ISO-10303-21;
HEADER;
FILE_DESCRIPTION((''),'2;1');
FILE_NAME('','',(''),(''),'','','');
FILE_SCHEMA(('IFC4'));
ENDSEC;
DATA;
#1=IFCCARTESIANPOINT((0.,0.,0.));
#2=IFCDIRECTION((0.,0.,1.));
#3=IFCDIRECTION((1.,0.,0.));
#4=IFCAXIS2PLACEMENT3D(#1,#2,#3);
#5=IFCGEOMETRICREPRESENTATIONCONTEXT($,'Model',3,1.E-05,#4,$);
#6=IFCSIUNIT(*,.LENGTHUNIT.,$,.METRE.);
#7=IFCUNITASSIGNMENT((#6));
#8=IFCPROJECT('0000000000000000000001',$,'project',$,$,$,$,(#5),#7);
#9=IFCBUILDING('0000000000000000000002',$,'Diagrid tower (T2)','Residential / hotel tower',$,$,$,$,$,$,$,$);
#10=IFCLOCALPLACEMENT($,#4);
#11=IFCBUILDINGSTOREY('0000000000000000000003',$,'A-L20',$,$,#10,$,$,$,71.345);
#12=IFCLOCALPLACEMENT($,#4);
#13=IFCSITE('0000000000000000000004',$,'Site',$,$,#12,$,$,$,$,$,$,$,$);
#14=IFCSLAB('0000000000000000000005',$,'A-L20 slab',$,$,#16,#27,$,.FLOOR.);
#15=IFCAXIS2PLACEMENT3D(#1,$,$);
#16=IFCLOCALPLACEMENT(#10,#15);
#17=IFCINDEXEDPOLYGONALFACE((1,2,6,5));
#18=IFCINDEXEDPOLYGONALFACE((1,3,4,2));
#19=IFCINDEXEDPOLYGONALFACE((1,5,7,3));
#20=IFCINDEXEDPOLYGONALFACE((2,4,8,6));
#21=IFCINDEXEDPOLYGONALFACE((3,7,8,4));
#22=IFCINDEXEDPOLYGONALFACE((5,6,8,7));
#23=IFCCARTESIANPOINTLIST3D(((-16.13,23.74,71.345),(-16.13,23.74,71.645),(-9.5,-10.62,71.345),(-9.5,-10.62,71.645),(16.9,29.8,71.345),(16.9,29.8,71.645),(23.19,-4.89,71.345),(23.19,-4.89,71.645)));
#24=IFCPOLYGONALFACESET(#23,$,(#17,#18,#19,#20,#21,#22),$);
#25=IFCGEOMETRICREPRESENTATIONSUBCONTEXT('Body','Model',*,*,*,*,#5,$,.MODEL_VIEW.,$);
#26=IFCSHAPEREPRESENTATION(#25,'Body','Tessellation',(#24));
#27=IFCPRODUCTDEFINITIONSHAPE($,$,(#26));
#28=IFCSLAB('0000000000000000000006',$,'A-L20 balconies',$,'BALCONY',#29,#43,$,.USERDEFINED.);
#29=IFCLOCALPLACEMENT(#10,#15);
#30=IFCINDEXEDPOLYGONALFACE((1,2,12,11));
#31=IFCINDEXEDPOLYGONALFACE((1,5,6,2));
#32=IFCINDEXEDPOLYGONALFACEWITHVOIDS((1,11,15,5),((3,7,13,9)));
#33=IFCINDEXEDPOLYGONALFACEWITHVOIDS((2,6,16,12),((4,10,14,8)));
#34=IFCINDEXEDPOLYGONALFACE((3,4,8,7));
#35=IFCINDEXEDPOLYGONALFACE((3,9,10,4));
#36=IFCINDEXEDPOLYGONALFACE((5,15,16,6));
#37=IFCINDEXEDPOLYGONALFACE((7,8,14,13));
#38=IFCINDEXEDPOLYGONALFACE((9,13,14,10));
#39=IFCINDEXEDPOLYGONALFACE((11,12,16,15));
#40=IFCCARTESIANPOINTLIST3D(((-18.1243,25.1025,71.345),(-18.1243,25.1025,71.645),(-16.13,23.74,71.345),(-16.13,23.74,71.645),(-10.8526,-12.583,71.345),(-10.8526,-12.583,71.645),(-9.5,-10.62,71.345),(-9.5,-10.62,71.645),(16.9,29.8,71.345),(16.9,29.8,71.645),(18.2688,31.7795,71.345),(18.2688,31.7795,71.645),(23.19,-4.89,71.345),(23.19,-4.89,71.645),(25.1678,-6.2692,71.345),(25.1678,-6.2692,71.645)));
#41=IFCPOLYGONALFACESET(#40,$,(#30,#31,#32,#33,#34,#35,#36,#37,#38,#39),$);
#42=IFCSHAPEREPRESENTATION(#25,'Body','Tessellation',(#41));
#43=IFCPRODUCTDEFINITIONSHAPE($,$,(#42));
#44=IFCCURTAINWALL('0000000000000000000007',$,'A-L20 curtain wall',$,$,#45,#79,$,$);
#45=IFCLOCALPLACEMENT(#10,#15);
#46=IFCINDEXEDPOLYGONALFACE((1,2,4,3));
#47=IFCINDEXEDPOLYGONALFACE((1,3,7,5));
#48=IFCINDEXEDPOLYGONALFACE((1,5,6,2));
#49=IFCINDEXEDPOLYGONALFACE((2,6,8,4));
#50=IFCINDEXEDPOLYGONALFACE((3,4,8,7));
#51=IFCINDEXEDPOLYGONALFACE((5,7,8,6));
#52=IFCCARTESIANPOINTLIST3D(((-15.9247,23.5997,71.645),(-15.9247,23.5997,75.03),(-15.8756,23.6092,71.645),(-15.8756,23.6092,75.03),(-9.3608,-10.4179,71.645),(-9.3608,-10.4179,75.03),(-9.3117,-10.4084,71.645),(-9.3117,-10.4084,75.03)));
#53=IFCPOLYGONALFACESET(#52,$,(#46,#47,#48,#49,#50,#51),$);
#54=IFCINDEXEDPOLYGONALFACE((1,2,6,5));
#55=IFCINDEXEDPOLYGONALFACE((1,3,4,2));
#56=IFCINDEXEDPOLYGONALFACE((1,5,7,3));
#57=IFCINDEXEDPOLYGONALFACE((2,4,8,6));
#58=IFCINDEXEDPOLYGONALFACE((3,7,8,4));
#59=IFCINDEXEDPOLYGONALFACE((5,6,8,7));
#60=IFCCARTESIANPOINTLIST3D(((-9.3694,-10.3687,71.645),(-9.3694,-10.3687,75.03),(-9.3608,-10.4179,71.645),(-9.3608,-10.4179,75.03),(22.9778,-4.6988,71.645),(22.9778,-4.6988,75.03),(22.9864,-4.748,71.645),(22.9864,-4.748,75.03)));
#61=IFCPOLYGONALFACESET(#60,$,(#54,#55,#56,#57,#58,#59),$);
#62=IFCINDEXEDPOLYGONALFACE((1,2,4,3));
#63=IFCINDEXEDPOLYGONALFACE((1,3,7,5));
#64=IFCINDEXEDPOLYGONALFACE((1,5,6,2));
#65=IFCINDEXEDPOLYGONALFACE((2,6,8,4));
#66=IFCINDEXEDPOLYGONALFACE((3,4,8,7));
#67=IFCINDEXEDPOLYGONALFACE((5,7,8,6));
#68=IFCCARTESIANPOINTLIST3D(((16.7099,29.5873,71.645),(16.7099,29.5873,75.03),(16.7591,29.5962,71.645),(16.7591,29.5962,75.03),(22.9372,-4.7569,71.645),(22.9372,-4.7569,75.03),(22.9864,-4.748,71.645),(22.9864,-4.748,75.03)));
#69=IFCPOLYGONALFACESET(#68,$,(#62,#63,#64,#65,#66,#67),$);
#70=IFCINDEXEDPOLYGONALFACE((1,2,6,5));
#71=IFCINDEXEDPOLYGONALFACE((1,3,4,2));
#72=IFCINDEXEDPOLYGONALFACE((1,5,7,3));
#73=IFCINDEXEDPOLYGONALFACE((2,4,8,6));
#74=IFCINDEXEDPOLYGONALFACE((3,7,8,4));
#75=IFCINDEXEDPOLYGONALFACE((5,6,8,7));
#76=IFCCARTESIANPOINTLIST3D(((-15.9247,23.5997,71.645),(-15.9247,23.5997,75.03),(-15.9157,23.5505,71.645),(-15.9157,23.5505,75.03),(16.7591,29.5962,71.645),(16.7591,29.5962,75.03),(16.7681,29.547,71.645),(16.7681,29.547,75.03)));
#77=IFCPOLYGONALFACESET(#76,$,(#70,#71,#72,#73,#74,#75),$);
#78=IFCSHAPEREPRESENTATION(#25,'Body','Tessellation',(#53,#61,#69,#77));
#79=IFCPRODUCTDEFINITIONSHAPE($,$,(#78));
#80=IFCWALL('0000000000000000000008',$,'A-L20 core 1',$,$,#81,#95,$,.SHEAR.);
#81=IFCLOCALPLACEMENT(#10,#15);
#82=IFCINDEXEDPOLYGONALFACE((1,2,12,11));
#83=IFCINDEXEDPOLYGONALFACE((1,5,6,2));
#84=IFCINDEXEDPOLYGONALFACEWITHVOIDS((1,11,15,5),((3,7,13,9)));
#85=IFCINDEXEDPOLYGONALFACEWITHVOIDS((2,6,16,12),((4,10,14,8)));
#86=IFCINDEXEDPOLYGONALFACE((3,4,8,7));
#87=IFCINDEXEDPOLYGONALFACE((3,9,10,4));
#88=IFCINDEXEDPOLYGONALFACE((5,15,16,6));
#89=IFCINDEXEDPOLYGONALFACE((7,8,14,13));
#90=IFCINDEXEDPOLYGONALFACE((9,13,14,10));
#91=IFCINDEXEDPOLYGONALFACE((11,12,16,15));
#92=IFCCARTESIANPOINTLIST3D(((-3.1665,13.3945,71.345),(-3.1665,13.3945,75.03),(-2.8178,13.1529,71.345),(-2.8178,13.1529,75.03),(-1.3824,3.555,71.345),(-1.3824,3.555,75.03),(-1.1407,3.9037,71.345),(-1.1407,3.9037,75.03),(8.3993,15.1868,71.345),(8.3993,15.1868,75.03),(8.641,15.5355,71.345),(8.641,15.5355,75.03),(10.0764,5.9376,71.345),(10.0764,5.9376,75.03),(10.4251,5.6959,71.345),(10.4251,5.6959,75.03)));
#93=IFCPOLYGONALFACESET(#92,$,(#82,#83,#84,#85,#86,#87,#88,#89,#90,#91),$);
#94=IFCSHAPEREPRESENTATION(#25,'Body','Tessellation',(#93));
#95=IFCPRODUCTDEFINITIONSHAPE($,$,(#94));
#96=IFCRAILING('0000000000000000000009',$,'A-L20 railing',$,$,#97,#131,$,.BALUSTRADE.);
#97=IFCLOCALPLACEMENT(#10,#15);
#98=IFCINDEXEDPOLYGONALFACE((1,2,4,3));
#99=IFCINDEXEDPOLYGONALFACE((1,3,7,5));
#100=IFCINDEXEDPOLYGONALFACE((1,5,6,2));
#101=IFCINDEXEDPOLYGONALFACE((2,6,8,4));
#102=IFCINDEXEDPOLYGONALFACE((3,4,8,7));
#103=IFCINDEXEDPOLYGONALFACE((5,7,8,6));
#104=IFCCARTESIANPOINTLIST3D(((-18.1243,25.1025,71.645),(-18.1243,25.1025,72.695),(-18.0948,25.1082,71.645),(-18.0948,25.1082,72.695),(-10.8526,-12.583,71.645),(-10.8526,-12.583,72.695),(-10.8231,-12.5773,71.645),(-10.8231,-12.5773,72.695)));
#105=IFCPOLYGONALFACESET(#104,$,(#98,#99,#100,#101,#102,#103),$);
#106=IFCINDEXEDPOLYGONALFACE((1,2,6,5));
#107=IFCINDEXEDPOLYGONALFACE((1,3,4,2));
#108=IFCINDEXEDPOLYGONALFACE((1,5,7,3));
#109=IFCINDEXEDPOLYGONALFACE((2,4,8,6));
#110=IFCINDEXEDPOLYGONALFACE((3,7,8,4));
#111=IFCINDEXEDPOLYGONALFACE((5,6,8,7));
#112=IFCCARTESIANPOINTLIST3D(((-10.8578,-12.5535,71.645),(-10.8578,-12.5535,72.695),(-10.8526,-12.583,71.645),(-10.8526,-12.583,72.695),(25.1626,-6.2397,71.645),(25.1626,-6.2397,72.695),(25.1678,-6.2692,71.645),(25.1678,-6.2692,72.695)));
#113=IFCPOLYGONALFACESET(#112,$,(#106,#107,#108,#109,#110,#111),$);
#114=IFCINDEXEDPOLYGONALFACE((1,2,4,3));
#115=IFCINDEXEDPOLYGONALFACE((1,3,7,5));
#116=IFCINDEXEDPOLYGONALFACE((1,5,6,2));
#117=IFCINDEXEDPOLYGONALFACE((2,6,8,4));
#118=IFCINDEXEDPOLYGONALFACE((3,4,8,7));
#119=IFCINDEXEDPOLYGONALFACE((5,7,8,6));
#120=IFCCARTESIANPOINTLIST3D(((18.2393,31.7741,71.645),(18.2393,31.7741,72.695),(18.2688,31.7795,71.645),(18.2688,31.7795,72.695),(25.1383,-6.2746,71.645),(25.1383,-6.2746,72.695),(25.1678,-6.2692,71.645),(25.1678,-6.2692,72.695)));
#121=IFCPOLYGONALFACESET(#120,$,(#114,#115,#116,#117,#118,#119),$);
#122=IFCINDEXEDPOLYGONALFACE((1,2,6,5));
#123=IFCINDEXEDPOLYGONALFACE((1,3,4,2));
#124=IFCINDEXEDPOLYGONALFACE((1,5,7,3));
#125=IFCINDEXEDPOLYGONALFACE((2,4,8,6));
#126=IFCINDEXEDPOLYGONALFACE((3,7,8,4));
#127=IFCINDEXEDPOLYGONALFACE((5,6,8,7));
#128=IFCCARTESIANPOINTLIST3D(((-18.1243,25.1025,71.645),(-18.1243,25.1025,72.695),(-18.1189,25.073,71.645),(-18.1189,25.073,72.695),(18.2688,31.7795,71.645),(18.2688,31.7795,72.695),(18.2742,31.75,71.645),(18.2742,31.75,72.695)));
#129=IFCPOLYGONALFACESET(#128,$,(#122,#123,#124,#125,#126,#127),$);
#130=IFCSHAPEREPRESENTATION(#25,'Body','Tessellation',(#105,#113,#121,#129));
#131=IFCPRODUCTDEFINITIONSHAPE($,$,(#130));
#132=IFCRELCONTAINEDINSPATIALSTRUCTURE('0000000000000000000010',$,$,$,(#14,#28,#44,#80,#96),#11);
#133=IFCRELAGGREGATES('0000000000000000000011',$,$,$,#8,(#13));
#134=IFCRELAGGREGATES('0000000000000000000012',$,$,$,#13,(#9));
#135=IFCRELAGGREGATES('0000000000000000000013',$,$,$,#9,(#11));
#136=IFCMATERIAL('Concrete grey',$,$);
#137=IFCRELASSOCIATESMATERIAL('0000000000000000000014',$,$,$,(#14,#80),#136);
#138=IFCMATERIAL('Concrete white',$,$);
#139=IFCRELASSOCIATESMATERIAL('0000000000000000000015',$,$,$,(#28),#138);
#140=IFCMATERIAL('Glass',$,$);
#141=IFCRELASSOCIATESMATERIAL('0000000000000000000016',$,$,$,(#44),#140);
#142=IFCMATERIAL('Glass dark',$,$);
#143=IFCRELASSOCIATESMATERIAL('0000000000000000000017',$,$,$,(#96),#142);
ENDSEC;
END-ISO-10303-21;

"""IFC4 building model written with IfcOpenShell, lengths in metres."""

from ifc_helpers import new_model, si_unit, frame, origin_with_axes, place, context, subcontext, project, spatial, polyline, outline, extrude, material, element, save


model = new_model("IFC4")

# Units and contexts
model_context = context("Model", 3, precision=1e-05, world=origin_with_axes())
body_context = subcontext(model_context, "Body", "Model", "MODEL_VIEW")
ifc_project = project(units=[si_unit("LENGTHUNIT", "METRE")], contexts=[model_context])

# Site, building, storey
site_placement = place(None, origin_with_axes())
site = spatial("IfcSite", under=ifc_project, at=site_placement, Name="Site")
building = spatial("IfcBuilding", under=site, Name="Diagrid tower (T2)", Description="Residential / hotel tower")
storey_placement = place(None, origin_with_axes())
storey = spatial("IfcBuildingStorey", under=building, at=storey_placement, Name="A-L20", Elevation=71.345)

# Slabs
ifc_material_1 = material(Name="Concrete grey")
slab_1_placement = place(storey_placement, origin_with_axes())
element("IfcSlab", 1, at=slab_1_placement, inside=storey, material=ifc_material_1, Name="A-L20 slab", PredefinedType="FLOOR", context=body_context, shape_type="SweptSolid", body=[
    extrude(outline(polyline([(-16.13, 23.74), (-9.5, -10.62), (23.19, -4.89), (16.9, 29.8), (-16.13, 23.74)])), frame((0.0, 0.0, 71.345), z_axis=(0.0, 0.0, 1.0), x_axis=(1.0, 0.0, 0.0)), (0.0, 0.0, 1.0), 0.3),
])
ifc_material_2 = material(Name="Concrete white")
slab_2_placement = place(storey_placement, origin_with_axes())
element("IfcSlab", 2, at=slab_2_placement, inside=storey, material=ifc_material_2, Name="A-L20 balconies", ObjectType="BALCONY", PredefinedType="USERDEFINED", context=body_context, shape_type="SweptSolid", body=[
    extrude(outline(polyline([(-18.1243, 25.1025), (-10.8526, -12.583), (25.1678, -6.2692), (18.2688, 31.7795), (-18.1243, 25.1025)]), holes=[polyline([(-16.13, 23.74), (-9.5, -10.62), (23.19, -4.89), (16.9, 29.8), (-16.13, 23.74)])]), frame((0.0, 0.0, 71.345), z_axis=(0.0, 0.0, 1.0), x_axis=(1.0, 0.0, 0.0)), (0.0, 0.0, 1.0), 0.3),
])

# Curtain wall
ifc_material_3 = material(Name="Glass")
curtain_wall_placement = place(storey_placement, origin_with_axes())
element("IfcCurtainWall", 3, at=curtain_wall_placement, inside=storey, material=ifc_material_3, Name="A-L20 curtain wall", context=body_context, shape_type="SweptSolid", body=[
    extrude(outline(polyline([(-15.9247, 23.5997), (-9.3608, -10.4179), (-9.3117, -10.4084), (-15.8756, 23.6092), (-15.9247, 23.5997)])), frame((0.0, 0.0, 71.645), z_axis=(0.0, 0.0, 1.0), x_axis=(1.0, 0.0, 0.0)), (0.0, 0.0, 1.0), 3.385),
    extrude(outline(polyline([(-9.3608, -10.4179), (22.9864, -4.748), (22.9778, -4.6988), (-9.3694, -10.3687), (-9.3608, -10.4179)])), frame((0.0, 0.0, 71.645), z_axis=(0.0, 0.0, 1.0), x_axis=(1.0, 0.0, 0.0)), (0.0, 0.0, 1.0), 3.385),
    extrude(outline(polyline([(22.9864, -4.748), (16.7591, 29.5962), (16.7099, 29.5873), (22.9372, -4.7569), (22.9864, -4.748)])), frame((0.0, 0.0, 71.645), z_axis=(0.0, 0.0, 1.0), x_axis=(1.0, 0.0, 0.0)), (0.0, 0.0, 1.0), 3.385),
    extrude(outline(polyline([(16.7591, 29.5962), (-15.9247, 23.5997), (-15.9157, 23.5505), (16.7681, 29.547), (16.7591, 29.5962)])), frame((0.0, 0.0, 71.645), z_axis=(0.0, 0.0, 1.0), x_axis=(1.0, 0.0, 0.0)), (0.0, 0.0, 1.0), 3.385),
])

# Wall
wall_placement = place(storey_placement, origin_with_axes())
element("IfcWall", 4, at=wall_placement, inside=storey, material=ifc_material_1, Name="A-L20 core 1", PredefinedType="SHEAR", context=body_context, shape_type="SweptSolid", body=[
    extrude(outline(polyline([(10.4251, 5.6959), (8.641, 15.5355), (-3.1665, 13.3945), (-1.3824, 3.555), (10.4251, 5.6959)]), holes=[polyline([(10.0764, 5.9376), (8.3993, 15.1868), (-2.8178, 13.1529), (-1.1407, 3.9037), (10.0764, 5.9376)])]), frame((0.0, 0.0, 71.345), z_axis=(0.0, 0.0, 1.0), x_axis=(1.0, 0.0, 0.0)), (0.0, 0.0, 1.0), 3.685),
])

# Railing
ifc_material_4 = material(Name="Glass dark")
railing_placement = place(storey_placement, origin_with_axes())
element("IfcRailing", 5, at=railing_placement, inside=storey, material=ifc_material_4, Name="A-L20 railing", PredefinedType="BALUSTRADE", context=body_context, shape_type="SweptSolid", body=[
    extrude(outline(polyline([(-18.1243, 25.1025), (-10.8526, -12.583), (-10.8231, -12.5773), (-18.0948, 25.1082), (-18.1243, 25.1025)])), frame((0.0, 0.0, 71.645), z_axis=(0.0, 0.0, 1.0), x_axis=(1.0, 0.0, 0.0)), (0.0, 0.0, 1.0), 1.05),
    extrude(outline(polyline([(-10.8526, -12.583), (25.1678, -6.2692), (25.1626, -6.2397), (-10.8578, -12.5535), (-10.8526, -12.583)])), frame((0.0, 0.0, 71.645), z_axis=(0.0, 0.0, 1.0), x_axis=(1.0, 0.0, 0.0)), (0.0, 0.0, 1.0), 1.05),
    extrude(outline(polyline([(25.1678, -6.2692), (18.2688, 31.7795), (18.2393, 31.7741), (25.1383, -6.2746), (25.1678, -6.2692)])), frame((0.0, 0.0, 71.645), z_axis=(0.0, 0.0, 1.0), x_axis=(1.0, 0.0, 0.0)), (0.0, 0.0, 1.0), 1.05),
    extrude(outline(polyline([(18.2688, 31.7795), (-18.1243, 25.1025), (-18.1189, 25.073), (18.2742, 31.75), (18.2688, 31.7795)])), frame((0.0, 0.0, 71.645), z_axis=(0.0, 0.0, 1.0), x_axis=(1.0, 0.0, 0.0)), (0.0, 0.0, 1.0), 1.05),
])

save(model, "model.ifc")
